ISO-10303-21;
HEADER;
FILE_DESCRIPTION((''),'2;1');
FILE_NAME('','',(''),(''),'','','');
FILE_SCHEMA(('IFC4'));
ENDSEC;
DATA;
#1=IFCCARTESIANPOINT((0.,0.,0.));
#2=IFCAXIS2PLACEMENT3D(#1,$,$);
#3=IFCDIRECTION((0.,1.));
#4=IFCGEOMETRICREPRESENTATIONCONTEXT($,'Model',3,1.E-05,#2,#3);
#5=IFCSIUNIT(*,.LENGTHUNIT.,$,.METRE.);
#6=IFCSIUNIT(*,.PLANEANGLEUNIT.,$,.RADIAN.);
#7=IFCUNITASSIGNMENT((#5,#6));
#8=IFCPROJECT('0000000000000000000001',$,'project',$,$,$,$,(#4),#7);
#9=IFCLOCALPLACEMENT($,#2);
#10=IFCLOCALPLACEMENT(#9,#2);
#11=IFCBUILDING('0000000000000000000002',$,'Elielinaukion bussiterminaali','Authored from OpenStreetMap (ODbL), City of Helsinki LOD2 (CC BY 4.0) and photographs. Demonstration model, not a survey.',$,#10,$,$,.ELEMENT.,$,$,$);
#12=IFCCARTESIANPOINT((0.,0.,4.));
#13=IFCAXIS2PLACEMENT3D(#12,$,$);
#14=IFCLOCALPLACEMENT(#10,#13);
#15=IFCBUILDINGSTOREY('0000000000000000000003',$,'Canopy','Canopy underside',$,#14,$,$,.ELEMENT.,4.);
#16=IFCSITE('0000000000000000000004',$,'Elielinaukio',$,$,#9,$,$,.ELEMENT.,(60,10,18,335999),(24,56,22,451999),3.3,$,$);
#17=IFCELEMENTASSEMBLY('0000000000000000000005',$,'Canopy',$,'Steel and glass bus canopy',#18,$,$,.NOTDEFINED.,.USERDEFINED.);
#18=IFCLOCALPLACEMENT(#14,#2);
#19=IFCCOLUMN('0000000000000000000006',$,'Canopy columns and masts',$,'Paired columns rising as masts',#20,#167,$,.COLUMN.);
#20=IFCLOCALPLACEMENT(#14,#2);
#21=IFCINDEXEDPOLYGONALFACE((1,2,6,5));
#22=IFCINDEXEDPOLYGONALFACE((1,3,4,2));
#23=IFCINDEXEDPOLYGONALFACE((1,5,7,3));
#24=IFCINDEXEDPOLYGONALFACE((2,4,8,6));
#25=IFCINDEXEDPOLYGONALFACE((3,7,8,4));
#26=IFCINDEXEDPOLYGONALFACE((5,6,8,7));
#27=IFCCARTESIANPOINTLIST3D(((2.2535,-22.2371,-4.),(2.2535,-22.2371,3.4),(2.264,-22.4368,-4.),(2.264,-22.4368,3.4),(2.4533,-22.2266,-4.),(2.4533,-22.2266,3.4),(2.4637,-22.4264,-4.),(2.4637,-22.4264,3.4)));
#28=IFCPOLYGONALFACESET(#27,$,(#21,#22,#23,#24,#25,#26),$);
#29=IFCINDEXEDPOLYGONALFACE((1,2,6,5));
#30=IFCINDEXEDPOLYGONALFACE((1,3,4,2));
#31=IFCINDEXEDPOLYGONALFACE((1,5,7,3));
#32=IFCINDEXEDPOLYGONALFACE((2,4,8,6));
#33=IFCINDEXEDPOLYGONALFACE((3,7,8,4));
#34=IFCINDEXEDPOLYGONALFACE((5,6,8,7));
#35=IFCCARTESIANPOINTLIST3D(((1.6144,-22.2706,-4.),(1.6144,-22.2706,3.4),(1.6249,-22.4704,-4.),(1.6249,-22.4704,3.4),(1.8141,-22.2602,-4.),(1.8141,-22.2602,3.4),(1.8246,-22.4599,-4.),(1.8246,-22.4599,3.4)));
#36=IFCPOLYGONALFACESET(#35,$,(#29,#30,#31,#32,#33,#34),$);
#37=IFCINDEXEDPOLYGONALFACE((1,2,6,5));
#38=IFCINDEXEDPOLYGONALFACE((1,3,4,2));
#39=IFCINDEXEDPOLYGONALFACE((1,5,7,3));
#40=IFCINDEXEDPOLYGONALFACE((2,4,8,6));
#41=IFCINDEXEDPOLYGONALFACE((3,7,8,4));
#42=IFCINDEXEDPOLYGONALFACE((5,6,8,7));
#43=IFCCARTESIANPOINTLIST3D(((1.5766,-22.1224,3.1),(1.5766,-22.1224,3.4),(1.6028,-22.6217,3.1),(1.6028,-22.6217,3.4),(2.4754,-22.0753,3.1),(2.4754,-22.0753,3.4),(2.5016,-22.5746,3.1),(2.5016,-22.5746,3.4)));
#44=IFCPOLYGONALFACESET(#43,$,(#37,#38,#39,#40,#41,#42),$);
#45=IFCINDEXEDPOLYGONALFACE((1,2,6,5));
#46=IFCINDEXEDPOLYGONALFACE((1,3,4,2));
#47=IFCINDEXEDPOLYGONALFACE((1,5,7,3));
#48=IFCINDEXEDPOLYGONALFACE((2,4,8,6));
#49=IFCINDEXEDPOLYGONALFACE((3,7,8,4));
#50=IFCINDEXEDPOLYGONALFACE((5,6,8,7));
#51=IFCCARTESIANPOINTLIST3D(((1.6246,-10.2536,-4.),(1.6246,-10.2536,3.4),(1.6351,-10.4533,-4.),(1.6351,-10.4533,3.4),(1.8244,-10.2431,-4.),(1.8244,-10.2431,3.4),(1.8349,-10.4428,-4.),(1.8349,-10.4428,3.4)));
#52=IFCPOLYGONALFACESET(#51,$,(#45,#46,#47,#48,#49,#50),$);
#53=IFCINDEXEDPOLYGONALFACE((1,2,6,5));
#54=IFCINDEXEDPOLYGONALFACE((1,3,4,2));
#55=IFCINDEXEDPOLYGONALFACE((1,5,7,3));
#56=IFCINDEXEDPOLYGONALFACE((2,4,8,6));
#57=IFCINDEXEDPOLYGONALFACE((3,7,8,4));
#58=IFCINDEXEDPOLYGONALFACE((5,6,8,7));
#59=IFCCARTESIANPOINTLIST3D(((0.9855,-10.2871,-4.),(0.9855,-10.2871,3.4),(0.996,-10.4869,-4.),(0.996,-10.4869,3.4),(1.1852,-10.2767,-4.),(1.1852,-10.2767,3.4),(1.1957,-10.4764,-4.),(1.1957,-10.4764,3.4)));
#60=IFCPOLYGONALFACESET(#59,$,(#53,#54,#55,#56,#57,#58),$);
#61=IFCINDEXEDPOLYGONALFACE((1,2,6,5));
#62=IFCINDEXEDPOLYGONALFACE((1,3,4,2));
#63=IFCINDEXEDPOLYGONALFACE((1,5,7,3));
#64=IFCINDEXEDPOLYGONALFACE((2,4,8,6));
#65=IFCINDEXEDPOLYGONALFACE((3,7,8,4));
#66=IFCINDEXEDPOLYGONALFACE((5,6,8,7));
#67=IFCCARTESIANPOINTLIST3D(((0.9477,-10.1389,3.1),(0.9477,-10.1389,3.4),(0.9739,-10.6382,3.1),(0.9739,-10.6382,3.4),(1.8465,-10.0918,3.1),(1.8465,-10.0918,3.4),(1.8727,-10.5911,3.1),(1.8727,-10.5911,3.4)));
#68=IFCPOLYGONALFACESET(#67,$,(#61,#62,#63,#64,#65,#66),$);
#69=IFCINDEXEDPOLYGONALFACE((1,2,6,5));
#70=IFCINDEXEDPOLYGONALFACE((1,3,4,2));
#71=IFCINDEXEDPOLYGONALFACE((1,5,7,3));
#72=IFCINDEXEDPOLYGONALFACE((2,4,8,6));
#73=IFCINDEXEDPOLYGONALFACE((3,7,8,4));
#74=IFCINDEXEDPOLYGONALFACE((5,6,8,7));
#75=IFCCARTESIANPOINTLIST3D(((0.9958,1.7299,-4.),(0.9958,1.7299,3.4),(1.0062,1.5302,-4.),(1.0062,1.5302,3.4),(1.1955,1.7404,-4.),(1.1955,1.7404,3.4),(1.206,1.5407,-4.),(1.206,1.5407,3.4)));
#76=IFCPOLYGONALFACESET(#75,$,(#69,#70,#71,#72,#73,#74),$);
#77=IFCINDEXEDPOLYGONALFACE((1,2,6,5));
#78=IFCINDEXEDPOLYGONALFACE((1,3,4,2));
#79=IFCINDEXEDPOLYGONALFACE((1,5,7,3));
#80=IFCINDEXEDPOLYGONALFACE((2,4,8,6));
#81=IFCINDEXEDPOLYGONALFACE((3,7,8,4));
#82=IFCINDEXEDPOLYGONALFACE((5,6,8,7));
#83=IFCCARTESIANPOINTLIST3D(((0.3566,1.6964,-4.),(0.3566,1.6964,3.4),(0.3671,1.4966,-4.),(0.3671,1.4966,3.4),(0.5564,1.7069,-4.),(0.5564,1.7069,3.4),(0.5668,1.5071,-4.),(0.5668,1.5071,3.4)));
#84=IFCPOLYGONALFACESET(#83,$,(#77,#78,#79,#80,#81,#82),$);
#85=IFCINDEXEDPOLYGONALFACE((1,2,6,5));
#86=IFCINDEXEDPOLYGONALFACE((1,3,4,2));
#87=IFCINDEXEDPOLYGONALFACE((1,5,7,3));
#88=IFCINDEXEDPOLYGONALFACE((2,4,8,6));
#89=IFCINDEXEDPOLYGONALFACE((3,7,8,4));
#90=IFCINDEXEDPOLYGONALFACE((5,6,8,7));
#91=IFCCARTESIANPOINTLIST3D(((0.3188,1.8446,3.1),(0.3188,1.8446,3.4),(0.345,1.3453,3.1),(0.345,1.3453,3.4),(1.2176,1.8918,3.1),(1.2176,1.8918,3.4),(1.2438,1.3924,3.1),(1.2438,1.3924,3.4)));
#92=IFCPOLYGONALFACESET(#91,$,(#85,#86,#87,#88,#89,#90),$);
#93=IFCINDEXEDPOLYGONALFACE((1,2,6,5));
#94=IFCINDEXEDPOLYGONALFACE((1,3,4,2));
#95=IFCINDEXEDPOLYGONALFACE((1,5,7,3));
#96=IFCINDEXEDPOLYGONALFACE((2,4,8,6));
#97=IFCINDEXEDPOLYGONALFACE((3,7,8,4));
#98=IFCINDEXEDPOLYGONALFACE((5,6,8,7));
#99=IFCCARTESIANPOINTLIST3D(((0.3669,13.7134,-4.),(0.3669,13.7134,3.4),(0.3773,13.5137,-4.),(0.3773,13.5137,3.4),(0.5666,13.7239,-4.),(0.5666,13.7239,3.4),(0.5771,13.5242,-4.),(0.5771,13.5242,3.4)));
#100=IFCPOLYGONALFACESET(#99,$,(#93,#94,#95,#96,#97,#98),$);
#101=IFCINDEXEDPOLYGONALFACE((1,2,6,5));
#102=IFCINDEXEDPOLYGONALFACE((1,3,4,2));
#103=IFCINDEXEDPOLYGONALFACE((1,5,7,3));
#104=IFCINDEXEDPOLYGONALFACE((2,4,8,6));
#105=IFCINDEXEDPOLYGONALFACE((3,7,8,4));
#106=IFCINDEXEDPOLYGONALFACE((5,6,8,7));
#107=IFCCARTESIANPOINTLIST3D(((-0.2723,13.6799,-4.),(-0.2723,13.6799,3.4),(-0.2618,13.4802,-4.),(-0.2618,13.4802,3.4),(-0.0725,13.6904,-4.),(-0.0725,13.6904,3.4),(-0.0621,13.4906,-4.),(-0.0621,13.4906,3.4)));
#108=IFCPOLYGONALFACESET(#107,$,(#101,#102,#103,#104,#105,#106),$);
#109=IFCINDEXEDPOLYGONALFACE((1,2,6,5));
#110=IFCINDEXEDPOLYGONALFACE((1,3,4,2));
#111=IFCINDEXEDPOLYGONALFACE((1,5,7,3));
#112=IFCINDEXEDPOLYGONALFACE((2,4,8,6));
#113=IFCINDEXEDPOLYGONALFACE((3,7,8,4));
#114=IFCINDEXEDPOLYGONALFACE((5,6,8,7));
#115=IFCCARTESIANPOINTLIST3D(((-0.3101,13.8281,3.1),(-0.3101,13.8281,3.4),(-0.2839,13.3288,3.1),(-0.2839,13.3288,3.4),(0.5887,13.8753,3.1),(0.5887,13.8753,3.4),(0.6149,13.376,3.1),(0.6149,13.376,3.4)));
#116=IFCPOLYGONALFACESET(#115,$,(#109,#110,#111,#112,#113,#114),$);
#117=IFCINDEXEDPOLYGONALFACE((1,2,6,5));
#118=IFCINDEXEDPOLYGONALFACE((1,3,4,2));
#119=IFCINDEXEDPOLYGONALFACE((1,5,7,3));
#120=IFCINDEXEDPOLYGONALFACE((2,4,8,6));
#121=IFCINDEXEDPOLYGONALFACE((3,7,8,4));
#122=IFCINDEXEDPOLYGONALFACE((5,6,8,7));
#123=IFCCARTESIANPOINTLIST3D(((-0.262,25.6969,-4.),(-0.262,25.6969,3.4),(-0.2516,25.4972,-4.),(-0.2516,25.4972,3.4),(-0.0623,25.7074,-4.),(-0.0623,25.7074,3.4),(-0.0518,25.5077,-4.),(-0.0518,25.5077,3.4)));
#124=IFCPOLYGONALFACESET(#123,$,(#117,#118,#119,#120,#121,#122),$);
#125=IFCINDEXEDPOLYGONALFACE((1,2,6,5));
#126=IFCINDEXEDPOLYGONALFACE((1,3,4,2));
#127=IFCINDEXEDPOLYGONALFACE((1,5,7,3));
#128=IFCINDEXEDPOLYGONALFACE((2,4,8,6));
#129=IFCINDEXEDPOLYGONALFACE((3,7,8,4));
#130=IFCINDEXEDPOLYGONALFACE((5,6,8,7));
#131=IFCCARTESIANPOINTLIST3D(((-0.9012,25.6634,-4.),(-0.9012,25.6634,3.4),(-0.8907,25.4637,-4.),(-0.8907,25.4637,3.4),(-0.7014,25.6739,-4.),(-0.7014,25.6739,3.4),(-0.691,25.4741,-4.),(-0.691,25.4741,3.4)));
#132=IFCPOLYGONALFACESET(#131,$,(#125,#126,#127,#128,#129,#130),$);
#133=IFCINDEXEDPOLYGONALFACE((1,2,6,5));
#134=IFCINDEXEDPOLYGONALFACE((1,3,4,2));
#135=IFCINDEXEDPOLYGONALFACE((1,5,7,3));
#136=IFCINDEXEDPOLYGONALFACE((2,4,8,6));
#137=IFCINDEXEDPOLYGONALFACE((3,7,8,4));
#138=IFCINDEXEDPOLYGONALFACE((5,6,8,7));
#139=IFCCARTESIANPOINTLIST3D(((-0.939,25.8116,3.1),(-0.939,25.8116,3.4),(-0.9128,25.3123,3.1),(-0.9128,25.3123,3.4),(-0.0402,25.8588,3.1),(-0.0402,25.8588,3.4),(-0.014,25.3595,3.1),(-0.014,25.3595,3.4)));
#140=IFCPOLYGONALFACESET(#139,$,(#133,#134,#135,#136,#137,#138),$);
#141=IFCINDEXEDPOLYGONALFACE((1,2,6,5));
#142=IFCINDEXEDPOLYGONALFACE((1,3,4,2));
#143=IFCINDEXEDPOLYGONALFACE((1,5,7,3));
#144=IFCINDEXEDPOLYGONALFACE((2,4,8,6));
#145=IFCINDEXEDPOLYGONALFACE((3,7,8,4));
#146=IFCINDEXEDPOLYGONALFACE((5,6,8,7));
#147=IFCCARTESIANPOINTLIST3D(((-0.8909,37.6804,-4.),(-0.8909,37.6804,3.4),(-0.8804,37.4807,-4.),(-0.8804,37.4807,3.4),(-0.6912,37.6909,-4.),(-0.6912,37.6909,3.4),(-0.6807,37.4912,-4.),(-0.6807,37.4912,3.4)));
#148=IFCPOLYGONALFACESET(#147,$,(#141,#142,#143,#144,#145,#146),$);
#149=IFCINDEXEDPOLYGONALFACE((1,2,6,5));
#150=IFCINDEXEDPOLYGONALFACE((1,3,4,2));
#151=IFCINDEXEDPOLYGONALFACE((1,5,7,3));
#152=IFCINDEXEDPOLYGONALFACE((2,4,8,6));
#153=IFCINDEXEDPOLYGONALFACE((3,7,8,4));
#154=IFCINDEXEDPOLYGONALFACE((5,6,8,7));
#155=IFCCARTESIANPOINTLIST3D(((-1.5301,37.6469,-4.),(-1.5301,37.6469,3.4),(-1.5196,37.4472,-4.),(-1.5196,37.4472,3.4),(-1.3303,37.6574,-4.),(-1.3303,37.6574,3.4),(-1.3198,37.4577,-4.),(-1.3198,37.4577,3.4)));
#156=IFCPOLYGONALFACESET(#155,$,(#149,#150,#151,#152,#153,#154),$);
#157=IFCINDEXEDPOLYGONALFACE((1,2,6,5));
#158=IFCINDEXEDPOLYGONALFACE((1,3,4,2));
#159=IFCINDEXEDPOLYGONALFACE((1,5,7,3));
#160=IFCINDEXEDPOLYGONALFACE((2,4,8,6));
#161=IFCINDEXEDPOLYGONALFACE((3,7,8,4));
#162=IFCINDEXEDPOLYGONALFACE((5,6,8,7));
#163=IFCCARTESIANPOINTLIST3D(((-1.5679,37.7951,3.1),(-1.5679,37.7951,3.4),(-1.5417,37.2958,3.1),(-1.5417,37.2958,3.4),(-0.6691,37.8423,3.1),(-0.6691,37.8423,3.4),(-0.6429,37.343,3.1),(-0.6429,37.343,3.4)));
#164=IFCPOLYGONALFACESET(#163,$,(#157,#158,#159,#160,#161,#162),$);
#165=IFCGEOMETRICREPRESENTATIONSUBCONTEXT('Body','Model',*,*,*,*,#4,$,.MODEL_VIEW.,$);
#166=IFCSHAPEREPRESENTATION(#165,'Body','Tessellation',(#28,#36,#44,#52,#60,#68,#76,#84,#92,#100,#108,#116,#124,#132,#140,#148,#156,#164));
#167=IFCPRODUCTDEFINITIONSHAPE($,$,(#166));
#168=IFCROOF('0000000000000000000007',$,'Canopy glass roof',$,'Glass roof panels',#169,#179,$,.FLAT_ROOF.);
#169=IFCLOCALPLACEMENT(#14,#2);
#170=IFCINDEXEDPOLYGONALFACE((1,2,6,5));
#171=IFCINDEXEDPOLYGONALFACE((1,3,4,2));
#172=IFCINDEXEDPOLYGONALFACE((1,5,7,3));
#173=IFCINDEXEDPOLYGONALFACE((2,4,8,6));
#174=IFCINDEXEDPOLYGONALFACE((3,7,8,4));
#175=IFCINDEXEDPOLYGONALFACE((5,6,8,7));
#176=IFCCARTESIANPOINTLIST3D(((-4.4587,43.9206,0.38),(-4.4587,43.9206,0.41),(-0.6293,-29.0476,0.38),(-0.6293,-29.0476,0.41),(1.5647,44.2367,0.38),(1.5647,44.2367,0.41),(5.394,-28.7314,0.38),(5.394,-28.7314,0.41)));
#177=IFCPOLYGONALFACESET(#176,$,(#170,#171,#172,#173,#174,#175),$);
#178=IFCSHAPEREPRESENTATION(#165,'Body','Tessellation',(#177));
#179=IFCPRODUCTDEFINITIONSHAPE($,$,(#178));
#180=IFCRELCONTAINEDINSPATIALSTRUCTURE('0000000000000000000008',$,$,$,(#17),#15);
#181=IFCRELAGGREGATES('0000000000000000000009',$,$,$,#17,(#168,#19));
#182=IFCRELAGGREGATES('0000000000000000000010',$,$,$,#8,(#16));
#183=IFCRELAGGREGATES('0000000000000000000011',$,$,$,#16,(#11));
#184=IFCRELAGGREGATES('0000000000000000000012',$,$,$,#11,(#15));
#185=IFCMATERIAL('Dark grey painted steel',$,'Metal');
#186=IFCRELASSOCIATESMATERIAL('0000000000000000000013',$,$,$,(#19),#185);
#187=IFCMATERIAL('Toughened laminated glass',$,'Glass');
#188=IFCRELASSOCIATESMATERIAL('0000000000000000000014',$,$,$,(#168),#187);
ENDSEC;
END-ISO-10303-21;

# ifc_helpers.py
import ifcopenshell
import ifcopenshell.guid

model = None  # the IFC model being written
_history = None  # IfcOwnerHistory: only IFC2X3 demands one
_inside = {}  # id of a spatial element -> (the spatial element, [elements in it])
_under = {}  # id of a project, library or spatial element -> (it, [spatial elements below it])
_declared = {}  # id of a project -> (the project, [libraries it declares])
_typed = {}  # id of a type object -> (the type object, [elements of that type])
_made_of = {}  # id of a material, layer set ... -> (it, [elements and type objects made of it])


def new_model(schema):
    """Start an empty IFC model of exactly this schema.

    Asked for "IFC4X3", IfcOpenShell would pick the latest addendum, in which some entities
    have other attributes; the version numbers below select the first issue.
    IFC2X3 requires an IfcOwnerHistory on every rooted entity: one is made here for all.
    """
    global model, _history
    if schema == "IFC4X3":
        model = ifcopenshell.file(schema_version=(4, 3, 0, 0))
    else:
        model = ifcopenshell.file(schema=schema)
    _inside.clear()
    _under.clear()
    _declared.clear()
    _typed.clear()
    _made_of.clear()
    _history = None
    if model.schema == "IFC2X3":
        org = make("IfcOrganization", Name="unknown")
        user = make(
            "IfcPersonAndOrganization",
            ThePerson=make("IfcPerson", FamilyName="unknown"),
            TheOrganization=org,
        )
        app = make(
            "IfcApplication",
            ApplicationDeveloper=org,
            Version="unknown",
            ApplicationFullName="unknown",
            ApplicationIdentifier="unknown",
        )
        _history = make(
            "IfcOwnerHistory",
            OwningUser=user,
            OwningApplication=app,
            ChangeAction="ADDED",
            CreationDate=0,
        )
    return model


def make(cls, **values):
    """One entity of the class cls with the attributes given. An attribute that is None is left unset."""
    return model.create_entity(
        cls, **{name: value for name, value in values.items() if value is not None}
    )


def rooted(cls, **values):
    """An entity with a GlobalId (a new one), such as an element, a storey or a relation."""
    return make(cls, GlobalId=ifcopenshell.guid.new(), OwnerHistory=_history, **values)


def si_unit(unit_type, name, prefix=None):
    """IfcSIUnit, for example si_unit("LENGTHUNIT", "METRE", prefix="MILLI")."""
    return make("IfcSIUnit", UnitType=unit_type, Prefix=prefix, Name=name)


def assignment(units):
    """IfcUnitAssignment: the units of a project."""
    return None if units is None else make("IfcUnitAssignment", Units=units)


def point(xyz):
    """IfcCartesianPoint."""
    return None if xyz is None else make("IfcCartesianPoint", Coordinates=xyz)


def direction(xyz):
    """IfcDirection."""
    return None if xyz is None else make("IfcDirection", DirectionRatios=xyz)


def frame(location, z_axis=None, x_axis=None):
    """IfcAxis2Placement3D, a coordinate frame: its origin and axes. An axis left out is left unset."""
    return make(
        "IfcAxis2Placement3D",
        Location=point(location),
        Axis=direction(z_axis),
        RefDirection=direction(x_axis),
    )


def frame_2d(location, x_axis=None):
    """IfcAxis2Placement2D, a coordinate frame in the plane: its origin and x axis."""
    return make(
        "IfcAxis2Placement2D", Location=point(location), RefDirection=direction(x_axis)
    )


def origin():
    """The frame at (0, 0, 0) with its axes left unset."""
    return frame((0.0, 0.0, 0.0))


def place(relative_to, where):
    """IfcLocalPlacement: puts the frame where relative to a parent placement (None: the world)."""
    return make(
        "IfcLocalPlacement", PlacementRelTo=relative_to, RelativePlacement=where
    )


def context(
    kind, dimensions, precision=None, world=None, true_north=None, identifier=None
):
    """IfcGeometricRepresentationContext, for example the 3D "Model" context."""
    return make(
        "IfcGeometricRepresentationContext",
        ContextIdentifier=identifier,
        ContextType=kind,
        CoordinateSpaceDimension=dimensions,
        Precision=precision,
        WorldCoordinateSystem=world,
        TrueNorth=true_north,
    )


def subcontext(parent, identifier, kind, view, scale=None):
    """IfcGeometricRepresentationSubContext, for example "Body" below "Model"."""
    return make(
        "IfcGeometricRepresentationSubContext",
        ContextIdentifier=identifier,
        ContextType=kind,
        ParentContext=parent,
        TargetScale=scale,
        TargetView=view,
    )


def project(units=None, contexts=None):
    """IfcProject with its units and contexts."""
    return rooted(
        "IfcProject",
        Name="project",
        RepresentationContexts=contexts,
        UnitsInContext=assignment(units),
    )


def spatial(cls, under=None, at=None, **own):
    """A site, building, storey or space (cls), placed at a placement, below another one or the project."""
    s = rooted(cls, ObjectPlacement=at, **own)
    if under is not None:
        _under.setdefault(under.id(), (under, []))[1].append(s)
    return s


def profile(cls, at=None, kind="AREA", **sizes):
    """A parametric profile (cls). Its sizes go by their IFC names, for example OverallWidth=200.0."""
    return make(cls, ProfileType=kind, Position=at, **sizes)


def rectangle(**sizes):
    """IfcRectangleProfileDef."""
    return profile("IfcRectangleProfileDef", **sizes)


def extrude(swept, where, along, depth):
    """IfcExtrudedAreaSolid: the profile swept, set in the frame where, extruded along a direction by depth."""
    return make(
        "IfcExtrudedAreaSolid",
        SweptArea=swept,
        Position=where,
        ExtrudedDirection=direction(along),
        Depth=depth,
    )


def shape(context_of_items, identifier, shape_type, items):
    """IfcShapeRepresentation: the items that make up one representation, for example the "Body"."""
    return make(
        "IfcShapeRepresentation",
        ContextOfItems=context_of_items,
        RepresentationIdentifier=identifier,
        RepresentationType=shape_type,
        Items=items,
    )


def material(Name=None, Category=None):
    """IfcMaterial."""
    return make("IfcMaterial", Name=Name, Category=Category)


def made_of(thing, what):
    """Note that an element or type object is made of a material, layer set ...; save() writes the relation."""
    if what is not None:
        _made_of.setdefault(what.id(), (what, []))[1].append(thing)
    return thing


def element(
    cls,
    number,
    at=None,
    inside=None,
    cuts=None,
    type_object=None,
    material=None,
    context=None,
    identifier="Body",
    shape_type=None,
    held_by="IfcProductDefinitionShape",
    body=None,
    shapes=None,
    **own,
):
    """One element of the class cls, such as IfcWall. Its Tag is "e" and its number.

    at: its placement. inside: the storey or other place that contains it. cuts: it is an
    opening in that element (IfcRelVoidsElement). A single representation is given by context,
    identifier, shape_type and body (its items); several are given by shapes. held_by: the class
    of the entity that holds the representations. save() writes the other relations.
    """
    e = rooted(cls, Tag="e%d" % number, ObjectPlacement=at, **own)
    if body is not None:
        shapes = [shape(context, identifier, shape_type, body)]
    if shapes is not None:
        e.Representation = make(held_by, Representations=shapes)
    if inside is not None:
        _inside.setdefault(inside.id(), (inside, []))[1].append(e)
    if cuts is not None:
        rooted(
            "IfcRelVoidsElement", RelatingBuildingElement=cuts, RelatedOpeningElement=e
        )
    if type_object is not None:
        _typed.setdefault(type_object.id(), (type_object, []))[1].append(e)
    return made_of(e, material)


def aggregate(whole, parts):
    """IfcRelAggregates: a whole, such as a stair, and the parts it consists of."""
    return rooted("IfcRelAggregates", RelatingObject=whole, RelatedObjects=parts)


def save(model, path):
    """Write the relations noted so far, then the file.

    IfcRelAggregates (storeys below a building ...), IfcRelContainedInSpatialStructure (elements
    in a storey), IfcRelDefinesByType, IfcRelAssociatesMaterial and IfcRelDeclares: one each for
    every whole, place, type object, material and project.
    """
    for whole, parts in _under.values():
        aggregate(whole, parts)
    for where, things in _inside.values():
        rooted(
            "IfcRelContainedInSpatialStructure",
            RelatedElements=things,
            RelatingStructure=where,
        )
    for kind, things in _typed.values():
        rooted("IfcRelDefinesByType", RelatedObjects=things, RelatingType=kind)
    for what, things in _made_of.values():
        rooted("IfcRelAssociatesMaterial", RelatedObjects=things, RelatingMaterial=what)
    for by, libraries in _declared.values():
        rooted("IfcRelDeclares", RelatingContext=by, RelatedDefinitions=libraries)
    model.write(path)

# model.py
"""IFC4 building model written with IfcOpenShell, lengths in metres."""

from ifc_helpers import new_model, si_unit, direction, frame, frame_2d, origin, place, context, subcontext, project, spatial, rectangle, extrude, material, element, aggregate, save


model = new_model("IFC4")

# Units and contexts
model_context = context("Model", 3, precision=1e-05, world=origin(), true_north=direction((0.0, 1.0)))
body_context = subcontext(model_context, "Body", "Model", "MODEL_VIEW")
ifc_project = project(units=[si_unit("LENGTHUNIT", "METRE"), si_unit("PLANEANGLEUNIT", "RADIAN")], contexts=[model_context])

# Site, building, storey
site_placement = place(None, origin())
site = spatial("IfcSite", under=ifc_project, at=site_placement, Name="Elielinaukio", CompositionType="ELEMENT", RefLatitude=(60, 10, 18, 335999), RefLongitude=(24, 56, 22, 451999), RefElevation=3.3)
building_placement = place(site_placement, origin())
building = spatial("IfcBuilding", under=site, at=building_placement, Name="Elielinaukion bussiterminaali", Description="Authored from OpenStreetMap (ODbL), City of Helsinki LOD2 (CC BY 4.0) and photographs. Demonstration model, not a survey.", CompositionType="ELEMENT")
storey_placement = place(building_placement, frame((0.0, 0.0, 4.0)))
storey = spatial("IfcBuildingStorey", under=building, at=storey_placement, Name="Canopy", Description="Canopy underside", CompositionType="ELEMENT", Elevation=4.0)

# Element assembly, column, roof
assembly_placement = place(building_placement, origin())
assembly = element("IfcElementAssembly", 1, at=assembly_placement, inside=storey, Name="Canopy", ObjectType="Steel and glass bus canopy", AssemblyPlace="NOTDEFINED", PredefinedType="USERDEFINED")
ifc_material_1 = material(Name="Dark grey painted steel", Category="Metal")
column_placement = place(building_placement, origin())
column = element("IfcColumn", 2, at=column_placement, material=ifc_material_1, Name="Canopy columns and masts", ObjectType="Paired columns rising as masts", PredefinedType="COLUMN", context=body_context, shape_type="SweptSolid", body=[
    extrude(rectangle(XDim=0.2, YDim=0.2, at=frame_2d((0.0, 0.0), x_axis=(-0.052408, 0.998626))), frame((2.3586, -22.3317, 0.0)), (0.0, 0.0, 1.0), 7.4),
    extrude(rectangle(XDim=0.2, YDim=0.2, at=frame_2d((0.0, 0.0), x_axis=(-0.052408, 0.998626))), frame((1.7195, -22.3653, 0.0)), (0.0, 0.0, 1.0), 7.4),
    extrude(rectangle(XDim=0.5, YDim=0.9, at=frame_2d((0.0, 0.0), x_axis=(-0.052408, 0.998626))), frame((2.0391, -22.3485, 7.1)), (0.0, 0.0, 1.0), 0.3),
    extrude(rectangle(XDim=0.2, YDim=0.2, at=frame_2d((0.0, 0.0), x_axis=(-0.052408, 0.998626))), frame((1.7297, -10.3482, 0.0)), (0.0, 0.0, 1.0), 7.4),
    extrude(rectangle(XDim=0.2, YDim=0.2, at=frame_2d((0.0, 0.0), x_axis=(-0.052408, 0.998626))), frame((1.0906, -10.3818, 0.0)), (0.0, 0.0, 1.0), 7.4),
    extrude(rectangle(XDim=0.5, YDim=0.9, at=frame_2d((0.0, 0.0), x_axis=(-0.052408, 0.998626))), frame((1.4102, -10.365, 7.1)), (0.0, 0.0, 1.0), 0.3),
    extrude(rectangle(XDim=0.2, YDim=0.2, at=frame_2d((0.0, 0.0), x_axis=(-0.052408, 0.998626))), frame((1.1009, 1.6353, 0.0)), (0.0, 0.0, 1.0), 7.4),
    extrude(rectangle(XDim=0.2, YDim=0.2, at=frame_2d((0.0, 0.0), x_axis=(-0.052408, 0.998626))), frame((0.4617, 1.6017, 0.0)), (0.0, 0.0, 1.0), 7.4),
    extrude(rectangle(XDim=0.5, YDim=0.9, at=frame_2d((0.0, 0.0), x_axis=(-0.052408, 0.998626))), frame((0.7813, 1.6185, 7.1)), (0.0, 0.0, 1.0), 0.3),
    extrude(rectangle(XDim=0.2, YDim=0.2, at=frame_2d((0.0, 0.0), x_axis=(-0.052408, 0.998626))), frame((0.472, 13.6188, 0.0)), (0.0, 0.0, 1.0), 7.4),
    extrude(rectangle(XDim=0.2, YDim=0.2, at=frame_2d((0.0, 0.0), x_axis=(-0.052408, 0.998626))), frame((-0.1672, 13.5853, 0.0)), (0.0, 0.0, 1.0), 7.4),
    extrude(rectangle(XDim=0.5, YDim=0.9, at=frame_2d((0.0, 0.0), x_axis=(-0.052408, 0.998626))), frame((0.1524, 13.602, 7.1)), (0.0, 0.0, 1.0), 0.3),
    extrude(rectangle(XDim=0.2, YDim=0.2, at=frame_2d((0.0, 0.0), x_axis=(-0.052408, 0.998626))), frame((-0.1569, 25.6023, 0.0)), (0.0, 0.0, 1.0), 7.4),
    extrude(rectangle(XDim=0.2, YDim=0.2, at=frame_2d((0.0, 0.0), x_axis=(-0.052408, 0.998626))), frame((-0.7961, 25.5688, 0.0)), (0.0, 0.0, 1.0), 7.4),
    extrude(rectangle(XDim=0.5, YDim=0.9, at=frame_2d((0.0, 0.0), x_axis=(-0.052408, 0.998626))), frame((-0.4765, 25.5855, 7.1)), (0.0, 0.0, 1.0), 0.3),
    extrude(rectangle(XDim=0.2, YDim=0.2, at=frame_2d((0.0, 0.0), x_axis=(-0.052408, 0.998626))), frame((-0.7858, 37.5858, 0.0)), (0.0, 0.0, 1.0), 7.4),
    extrude(rectangle(XDim=0.2, YDim=0.2, at=frame_2d((0.0, 0.0), x_axis=(-0.052408, 0.998626))), frame((-1.4249, 37.5523, 0.0)), (0.0, 0.0, 1.0), 7.4),
    extrude(rectangle(XDim=0.5, YDim=0.9, at=frame_2d((0.0, 0.0), x_axis=(-0.052408, 0.998626))), frame((-1.1054, 37.569, 7.1)), (0.0, 0.0, 1.0), 0.3),
])
ifc_material_2 = material(Name="Toughened laminated glass", Category="Glass")
roof_placement = place(building_placement, origin())
roof = element("IfcRoof", 3, at=roof_placement, material=ifc_material_2, Name="Canopy glass roof", ObjectType="Glass roof panels", PredefinedType="FLAT_ROOF", context=body_context, shape_type="SweptSolid", body=[
    extrude(rectangle(XDim=73.0685, YDim=6.0317, at=frame_2d((0.0, 0.0), x_axis=(-0.052408, 0.998626))), frame((0.4677, 7.5946, 4.38)), (0.0, 0.0, 1.0), 0.03),
])
aggregate(assembly, [roof, column])

save(model, "model.ifc")
